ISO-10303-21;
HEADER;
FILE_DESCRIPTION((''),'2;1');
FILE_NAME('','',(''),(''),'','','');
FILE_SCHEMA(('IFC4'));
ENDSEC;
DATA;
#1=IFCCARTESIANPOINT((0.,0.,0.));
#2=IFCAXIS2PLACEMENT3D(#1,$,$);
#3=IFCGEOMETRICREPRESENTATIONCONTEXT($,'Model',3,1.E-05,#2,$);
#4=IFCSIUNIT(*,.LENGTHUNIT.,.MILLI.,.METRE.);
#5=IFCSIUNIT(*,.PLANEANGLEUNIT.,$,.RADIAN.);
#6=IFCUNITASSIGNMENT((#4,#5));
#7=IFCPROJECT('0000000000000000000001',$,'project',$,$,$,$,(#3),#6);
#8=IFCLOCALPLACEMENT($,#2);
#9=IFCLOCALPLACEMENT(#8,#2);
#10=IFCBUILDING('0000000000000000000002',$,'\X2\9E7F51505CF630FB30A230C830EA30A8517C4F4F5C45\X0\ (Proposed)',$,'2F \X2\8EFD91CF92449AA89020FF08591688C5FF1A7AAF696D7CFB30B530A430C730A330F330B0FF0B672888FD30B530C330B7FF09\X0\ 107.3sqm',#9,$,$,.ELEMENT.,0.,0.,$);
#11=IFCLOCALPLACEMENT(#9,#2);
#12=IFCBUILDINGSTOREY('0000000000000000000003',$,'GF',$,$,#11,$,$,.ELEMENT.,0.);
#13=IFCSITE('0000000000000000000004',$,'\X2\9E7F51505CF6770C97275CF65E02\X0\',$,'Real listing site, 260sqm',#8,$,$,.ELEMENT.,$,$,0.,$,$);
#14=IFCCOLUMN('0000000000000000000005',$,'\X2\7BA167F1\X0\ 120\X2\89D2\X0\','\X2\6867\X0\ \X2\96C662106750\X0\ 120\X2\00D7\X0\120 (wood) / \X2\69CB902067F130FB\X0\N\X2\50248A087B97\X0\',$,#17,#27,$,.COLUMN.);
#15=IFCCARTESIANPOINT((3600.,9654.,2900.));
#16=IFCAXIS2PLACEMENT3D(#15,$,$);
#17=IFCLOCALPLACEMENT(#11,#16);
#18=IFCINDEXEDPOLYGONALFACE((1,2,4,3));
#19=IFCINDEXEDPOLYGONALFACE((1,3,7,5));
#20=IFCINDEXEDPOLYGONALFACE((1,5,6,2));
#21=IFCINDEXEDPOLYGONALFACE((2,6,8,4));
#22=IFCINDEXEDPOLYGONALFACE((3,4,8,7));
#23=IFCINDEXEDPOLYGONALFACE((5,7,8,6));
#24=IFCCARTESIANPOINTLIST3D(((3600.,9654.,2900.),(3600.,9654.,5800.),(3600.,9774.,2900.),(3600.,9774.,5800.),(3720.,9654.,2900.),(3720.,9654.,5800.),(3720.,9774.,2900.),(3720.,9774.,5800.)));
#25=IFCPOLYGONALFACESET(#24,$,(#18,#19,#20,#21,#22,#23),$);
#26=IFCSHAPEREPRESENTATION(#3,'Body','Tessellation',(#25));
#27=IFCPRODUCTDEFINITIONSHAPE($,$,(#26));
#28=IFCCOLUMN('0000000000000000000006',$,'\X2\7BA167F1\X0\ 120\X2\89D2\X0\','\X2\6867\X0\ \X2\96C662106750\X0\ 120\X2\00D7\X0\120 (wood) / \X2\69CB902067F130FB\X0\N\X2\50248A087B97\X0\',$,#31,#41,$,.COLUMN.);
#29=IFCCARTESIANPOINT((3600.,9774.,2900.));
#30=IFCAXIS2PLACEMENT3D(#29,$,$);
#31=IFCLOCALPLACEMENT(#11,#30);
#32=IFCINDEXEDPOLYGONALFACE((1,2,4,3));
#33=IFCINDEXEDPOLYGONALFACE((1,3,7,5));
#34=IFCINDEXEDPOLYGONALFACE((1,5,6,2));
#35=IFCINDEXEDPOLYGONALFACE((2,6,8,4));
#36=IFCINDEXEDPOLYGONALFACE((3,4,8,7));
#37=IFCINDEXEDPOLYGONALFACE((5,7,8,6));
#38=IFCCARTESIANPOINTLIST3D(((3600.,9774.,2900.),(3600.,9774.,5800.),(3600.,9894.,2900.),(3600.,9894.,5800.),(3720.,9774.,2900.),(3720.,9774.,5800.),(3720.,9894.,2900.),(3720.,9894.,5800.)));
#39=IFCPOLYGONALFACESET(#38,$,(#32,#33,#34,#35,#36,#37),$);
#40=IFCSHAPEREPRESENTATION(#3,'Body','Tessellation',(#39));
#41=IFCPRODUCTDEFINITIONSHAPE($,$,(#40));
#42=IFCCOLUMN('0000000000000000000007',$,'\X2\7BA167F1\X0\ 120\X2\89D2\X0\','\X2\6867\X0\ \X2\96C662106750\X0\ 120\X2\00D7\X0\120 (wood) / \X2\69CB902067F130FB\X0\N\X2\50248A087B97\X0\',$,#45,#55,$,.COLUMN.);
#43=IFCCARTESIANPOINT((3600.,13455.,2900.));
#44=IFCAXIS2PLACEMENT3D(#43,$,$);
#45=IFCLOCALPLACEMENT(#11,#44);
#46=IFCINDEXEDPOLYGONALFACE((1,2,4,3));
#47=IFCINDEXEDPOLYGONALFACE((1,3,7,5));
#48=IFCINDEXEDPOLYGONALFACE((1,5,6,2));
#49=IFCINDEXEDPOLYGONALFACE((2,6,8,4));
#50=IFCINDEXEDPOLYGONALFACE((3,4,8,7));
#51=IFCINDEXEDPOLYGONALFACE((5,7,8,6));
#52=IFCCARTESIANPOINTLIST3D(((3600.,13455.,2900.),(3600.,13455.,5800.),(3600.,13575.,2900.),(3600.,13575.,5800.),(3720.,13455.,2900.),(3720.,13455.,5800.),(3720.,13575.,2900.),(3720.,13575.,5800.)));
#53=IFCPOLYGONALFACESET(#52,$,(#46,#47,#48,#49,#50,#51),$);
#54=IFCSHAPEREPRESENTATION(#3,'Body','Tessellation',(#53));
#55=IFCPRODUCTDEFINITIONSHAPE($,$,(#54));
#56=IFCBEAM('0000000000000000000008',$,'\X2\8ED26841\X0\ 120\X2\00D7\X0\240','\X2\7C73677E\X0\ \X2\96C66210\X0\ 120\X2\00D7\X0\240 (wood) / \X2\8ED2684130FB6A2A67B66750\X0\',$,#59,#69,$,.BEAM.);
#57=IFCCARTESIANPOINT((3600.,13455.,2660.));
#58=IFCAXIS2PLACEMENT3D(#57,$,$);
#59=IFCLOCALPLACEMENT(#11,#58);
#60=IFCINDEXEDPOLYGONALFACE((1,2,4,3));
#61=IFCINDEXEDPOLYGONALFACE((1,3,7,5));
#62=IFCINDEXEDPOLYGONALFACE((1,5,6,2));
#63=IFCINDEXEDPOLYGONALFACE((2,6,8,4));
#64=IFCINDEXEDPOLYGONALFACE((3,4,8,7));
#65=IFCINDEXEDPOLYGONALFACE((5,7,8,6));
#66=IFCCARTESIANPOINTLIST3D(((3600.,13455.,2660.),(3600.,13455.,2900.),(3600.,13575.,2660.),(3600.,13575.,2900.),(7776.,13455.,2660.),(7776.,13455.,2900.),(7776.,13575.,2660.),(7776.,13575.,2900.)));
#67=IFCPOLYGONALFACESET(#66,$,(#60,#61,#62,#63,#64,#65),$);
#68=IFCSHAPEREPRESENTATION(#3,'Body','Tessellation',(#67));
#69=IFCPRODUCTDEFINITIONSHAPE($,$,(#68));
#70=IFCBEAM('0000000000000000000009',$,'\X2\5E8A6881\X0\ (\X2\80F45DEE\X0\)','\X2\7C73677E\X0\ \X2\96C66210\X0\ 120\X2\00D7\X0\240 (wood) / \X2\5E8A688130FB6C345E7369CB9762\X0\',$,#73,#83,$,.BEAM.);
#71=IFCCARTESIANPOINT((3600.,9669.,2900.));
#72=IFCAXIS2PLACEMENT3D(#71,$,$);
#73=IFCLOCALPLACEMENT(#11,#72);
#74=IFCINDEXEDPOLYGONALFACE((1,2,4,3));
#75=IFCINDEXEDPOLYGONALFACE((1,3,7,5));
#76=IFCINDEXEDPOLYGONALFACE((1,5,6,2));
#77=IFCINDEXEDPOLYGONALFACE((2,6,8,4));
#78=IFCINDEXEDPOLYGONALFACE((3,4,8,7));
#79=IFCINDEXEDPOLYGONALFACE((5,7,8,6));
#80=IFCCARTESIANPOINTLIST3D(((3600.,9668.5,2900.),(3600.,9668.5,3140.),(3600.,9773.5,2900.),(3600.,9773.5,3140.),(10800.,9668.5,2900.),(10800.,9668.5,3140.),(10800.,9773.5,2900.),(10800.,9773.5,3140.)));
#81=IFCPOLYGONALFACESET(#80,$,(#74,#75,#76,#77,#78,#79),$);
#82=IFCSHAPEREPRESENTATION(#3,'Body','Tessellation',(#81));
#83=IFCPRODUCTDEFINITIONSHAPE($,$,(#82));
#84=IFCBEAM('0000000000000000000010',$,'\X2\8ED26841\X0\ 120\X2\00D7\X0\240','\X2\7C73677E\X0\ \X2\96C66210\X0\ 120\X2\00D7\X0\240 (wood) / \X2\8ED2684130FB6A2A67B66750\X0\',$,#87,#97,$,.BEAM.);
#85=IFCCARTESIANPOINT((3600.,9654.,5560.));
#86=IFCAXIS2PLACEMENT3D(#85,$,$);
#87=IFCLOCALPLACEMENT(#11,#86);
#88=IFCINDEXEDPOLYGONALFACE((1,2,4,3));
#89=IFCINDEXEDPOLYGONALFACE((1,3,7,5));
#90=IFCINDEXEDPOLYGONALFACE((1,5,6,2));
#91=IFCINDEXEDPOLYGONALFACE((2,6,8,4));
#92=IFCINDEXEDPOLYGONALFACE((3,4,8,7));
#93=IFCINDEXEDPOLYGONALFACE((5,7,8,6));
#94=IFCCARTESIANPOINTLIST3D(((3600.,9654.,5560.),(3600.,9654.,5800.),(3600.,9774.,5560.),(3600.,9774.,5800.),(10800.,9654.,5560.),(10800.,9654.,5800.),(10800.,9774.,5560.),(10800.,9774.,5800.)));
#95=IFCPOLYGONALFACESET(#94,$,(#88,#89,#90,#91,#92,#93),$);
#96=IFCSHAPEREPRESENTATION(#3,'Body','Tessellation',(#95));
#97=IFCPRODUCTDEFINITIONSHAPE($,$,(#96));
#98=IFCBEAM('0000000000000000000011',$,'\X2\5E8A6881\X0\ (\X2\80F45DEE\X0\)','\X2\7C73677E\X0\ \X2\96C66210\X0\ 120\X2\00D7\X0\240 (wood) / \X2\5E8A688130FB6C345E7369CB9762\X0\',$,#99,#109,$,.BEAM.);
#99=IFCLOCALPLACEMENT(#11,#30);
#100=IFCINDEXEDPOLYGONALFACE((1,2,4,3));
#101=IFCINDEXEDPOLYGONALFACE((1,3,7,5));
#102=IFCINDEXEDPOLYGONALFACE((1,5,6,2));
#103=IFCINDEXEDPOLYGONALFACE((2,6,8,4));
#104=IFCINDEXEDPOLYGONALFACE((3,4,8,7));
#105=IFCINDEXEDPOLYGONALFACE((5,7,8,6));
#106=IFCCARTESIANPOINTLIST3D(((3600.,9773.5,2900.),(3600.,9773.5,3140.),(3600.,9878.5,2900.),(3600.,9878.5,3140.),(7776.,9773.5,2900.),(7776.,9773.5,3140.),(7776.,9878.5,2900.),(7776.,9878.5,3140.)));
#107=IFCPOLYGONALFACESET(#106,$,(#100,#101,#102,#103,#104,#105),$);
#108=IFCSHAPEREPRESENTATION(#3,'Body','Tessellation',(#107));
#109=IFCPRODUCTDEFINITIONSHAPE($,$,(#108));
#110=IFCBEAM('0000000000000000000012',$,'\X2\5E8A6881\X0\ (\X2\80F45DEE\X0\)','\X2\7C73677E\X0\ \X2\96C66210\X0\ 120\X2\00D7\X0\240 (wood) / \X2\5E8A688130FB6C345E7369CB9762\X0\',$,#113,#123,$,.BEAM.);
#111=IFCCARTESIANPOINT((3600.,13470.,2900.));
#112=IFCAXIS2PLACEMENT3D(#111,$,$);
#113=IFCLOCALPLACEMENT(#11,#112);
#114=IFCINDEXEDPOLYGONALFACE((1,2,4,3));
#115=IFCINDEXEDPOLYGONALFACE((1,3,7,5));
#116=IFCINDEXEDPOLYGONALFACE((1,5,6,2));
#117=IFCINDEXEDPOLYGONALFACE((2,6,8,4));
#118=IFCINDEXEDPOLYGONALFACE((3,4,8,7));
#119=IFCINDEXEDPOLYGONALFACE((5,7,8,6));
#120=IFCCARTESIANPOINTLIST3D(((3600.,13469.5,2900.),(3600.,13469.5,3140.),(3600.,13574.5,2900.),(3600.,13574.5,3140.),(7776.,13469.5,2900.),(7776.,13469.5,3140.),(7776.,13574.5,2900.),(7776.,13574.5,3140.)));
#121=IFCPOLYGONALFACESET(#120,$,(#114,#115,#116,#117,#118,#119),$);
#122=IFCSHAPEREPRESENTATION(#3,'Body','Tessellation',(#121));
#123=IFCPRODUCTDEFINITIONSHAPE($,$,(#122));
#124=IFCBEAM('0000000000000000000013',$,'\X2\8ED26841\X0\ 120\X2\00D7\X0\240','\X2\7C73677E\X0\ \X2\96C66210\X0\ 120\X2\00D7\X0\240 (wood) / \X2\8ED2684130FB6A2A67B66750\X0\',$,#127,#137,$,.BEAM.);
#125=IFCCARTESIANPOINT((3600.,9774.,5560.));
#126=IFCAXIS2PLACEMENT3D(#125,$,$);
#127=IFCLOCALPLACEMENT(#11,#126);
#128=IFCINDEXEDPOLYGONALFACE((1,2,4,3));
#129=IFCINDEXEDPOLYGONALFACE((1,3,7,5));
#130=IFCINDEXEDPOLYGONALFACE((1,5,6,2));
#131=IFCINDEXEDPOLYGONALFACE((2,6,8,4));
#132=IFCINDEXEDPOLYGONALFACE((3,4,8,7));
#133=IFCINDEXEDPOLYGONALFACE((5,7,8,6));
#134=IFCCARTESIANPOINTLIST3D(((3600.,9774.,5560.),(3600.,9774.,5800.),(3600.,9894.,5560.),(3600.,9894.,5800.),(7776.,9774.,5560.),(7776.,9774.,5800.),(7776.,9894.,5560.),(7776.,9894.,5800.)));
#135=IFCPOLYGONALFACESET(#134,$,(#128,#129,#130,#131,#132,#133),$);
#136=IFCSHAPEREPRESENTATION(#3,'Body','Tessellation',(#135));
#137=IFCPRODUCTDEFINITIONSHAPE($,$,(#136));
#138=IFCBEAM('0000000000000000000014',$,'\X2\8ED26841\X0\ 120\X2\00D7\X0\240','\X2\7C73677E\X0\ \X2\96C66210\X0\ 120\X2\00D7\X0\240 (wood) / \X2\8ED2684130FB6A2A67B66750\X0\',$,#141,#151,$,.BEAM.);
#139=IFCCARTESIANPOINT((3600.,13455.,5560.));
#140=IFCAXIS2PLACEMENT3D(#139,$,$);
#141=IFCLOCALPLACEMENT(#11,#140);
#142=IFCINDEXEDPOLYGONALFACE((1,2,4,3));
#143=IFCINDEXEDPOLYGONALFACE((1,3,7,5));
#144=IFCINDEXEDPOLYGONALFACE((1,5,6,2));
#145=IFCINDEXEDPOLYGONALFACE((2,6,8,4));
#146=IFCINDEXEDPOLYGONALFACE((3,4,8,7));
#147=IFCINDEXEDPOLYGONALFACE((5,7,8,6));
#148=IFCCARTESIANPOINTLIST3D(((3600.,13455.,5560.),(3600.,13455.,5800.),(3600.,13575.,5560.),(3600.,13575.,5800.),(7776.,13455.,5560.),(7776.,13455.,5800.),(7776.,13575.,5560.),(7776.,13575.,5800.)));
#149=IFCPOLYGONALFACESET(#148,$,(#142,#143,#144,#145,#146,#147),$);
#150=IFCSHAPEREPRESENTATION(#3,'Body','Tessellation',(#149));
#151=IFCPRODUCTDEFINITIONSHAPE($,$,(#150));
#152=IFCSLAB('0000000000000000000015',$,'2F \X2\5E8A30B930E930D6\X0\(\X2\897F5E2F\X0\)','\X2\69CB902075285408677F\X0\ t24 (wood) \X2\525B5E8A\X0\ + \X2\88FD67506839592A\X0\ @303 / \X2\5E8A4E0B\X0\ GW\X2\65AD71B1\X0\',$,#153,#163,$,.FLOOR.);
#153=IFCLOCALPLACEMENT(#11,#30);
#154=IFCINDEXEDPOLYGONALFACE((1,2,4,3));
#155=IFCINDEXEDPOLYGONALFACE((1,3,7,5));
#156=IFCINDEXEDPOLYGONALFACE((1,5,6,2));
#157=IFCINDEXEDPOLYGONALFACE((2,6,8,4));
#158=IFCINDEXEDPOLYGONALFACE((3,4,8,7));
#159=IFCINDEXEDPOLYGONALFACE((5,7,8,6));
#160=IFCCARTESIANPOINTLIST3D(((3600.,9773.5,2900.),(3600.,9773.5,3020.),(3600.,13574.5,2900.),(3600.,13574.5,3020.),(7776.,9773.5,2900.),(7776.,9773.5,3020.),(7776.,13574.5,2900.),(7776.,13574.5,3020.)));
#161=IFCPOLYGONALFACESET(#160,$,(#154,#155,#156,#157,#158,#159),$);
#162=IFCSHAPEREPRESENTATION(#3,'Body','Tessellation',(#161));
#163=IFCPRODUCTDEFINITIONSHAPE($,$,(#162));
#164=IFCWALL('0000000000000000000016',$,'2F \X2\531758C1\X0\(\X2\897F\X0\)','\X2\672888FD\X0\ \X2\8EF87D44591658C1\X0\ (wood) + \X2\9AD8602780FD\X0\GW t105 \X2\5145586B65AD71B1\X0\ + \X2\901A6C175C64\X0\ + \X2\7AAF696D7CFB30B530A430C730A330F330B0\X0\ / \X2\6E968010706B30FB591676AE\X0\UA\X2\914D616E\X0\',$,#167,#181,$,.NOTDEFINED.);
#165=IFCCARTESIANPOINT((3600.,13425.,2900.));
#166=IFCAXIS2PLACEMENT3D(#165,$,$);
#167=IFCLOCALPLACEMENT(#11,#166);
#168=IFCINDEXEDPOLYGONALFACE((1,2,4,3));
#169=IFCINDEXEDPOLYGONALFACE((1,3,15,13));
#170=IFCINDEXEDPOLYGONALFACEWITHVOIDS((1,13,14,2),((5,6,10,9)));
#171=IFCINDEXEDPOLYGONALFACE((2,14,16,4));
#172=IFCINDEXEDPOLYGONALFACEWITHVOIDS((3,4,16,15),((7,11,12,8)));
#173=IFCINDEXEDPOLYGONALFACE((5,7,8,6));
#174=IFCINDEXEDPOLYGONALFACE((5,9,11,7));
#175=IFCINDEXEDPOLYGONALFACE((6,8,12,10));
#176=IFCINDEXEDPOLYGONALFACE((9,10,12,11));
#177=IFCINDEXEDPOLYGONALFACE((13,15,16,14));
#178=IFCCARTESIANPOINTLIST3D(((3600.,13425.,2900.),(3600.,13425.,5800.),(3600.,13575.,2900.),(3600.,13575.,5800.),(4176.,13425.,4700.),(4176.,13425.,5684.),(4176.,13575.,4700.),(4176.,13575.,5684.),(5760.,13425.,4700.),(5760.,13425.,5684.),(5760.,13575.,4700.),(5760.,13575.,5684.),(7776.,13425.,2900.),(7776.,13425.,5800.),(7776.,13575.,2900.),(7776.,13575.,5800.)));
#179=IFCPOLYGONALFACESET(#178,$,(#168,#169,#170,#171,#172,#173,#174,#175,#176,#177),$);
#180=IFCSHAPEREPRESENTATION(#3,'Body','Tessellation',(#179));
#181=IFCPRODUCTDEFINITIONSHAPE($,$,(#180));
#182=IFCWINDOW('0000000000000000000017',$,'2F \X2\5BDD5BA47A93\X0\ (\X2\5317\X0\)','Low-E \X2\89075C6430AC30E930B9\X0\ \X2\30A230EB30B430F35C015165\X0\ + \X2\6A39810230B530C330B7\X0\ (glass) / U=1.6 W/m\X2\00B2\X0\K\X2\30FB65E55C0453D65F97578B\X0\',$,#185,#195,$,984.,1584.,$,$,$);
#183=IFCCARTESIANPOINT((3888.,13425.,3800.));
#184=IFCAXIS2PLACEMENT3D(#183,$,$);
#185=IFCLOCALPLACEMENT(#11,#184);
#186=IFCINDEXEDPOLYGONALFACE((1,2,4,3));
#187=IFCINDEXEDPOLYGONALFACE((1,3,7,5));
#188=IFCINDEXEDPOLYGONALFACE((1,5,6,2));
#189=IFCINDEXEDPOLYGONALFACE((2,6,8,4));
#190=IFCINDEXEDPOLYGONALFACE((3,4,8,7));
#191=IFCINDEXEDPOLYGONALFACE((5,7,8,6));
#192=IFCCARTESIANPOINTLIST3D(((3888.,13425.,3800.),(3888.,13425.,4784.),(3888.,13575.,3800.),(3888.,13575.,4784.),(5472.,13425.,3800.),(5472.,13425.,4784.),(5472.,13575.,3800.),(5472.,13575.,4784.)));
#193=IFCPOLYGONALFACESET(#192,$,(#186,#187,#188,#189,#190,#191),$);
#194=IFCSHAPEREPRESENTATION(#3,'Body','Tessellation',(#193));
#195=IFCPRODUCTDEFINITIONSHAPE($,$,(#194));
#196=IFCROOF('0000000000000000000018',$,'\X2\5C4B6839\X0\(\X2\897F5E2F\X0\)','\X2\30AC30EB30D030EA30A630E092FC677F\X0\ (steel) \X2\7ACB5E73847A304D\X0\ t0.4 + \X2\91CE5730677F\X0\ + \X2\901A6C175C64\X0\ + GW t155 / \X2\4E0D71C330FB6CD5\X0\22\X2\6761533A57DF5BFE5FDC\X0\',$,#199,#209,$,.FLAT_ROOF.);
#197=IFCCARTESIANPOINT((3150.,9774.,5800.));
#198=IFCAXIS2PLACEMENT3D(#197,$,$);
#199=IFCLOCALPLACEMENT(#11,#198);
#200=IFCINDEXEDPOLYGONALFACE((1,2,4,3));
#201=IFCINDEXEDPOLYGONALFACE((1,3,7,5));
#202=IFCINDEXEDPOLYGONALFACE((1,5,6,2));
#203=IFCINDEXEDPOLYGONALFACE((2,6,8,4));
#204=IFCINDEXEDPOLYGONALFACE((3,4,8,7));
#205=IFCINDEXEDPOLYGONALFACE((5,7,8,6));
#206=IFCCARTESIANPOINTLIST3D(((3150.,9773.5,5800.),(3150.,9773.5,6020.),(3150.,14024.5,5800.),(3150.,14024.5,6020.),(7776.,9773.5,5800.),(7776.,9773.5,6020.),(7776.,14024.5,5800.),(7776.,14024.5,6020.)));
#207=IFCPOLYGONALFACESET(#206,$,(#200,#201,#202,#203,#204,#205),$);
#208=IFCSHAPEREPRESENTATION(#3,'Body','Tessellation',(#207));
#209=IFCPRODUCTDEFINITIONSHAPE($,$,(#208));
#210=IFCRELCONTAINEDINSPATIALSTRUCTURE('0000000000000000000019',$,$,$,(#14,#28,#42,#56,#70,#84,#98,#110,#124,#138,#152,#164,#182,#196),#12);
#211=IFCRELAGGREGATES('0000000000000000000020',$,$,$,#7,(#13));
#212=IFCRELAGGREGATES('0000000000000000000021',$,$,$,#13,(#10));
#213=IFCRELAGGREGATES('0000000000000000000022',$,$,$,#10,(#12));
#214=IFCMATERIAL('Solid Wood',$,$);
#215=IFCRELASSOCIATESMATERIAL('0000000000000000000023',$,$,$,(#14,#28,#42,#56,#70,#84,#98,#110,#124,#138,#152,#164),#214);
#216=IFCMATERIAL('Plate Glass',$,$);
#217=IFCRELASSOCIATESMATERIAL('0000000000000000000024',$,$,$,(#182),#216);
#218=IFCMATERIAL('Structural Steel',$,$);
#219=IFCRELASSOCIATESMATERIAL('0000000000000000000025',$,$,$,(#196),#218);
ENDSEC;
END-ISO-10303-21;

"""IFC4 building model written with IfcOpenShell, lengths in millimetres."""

from ifc_helpers import new_model, si_unit, frame, frame_2d, origin, place, context, project, spatial, rectangle, extrude, material, element, fill, save


model = new_model("IFC4")

# Units and contexts
model_context = context("Model", 3, precision=1e-05, world=origin())
ifc_project = project(units=[si_unit("LENGTHUNIT", "METRE", prefix="MILLI"), si_unit("PLANEANGLEUNIT", "RADIAN")], contexts=[model_context])

# Site, building, storey
site_placement = place(None, origin())
site = spatial("IfcSite", under=ifc_project, at=site_placement, Name="鹿児島県霧島市", ObjectType="Real listing site, 260sqm", CompositionType="ELEMENT", RefElevation=0.0)
building_placement = place(site_placement, origin())
building = spatial("IfcBuilding", under=site, at=building_placement, Name="鹿児島・アトリエ兼住居 (Proposed)", ObjectType="2F 軽量鉄骨造（外装：窯業系サイディング＋木製サッシ） 107.3sqm", CompositionType="ELEMENT", ElevationOfRefHeight=0.0, ElevationOfTerrain=0.0)
storey_placement = place(building_placement, origin())
storey = spatial("IfcBuildingStorey", under=building, at=storey_placement, Name="GF", CompositionType="ELEMENT", Elevation=0.0)

# Columns
ifc_material_1 = material(Name="Solid Wood")
column_1_placement = place(storey_placement, frame((3600.0, 9654.0, 2900.0)))
element("IfcColumn", 1, at=column_1_placement, inside=storey, material=ifc_material_1, Name="管柱 120角", Description="桧 集成材 120×120 (wood) / 構造柱・N値計算", PredefinedType="COLUMN", context=model_context, shape_type="SweptSolid", body=[
    extrude(rectangle(XDim=120.0, YDim=120.0, at=frame_2d((60.0, 60.0))), frame((3600.0, 9654.0, 2900.0)), (0.0, 0.0, 1.0), 2900.0),
])
column_2_placement = place(storey_placement, frame((3600.0, 9774.0, 2900.0)))
element("IfcColumn", 2, at=column_2_placement, inside=storey, material=ifc_material_1, Name="管柱 120角", Description="桧 集成材 120×120 (wood) / 構造柱・N値計算", PredefinedType="COLUMN", context=model_context, shape_type="SweptSolid", body=[
    extrude(rectangle(XDim=120.0, YDim=120.0, at=frame_2d((60.0, 60.0))), frame((3600.0, 9774.0, 2900.0)), (0.0, 0.0, 1.0), 2900.0),
])
column_3_placement = place(storey_placement, frame((3600.0, 13455.0, 2900.0)))
element("IfcColumn", 3, at=column_3_placement, inside=storey, material=ifc_material_1, Name="管柱 120角", Description="桧 集成材 120×120 (wood) / 構造柱・N値計算", PredefinedType="COLUMN", context=model_context, shape_type="SweptSolid", body=[
    extrude(rectangle(XDim=120.0, YDim=120.0, at=frame_2d((60.0, 60.0))), frame((3600.0, 13455.0, 2900.0)), (0.0, 0.0, 1.0), 2900.0),
])

# Beams
beam_1_placement = place(storey_placement, frame((3600.0, 13455.0, 2660.0)))
element("IfcBeam", 4, at=beam_1_placement, inside=storey, material=ifc_material_1, Name="軒桁 120×240", Description="米松 集成 120×240 (wood) / 軒桁・横架材", PredefinedType="BEAM", context=model_context, shape_type="SweptSolid", body=[
    extrude(rectangle(XDim=4176.0, YDim=120.0, at=frame_2d((2088.0, 60.0))), frame((3600.0, 13455.0, 2660.0)), (0.0, 0.0, 1.0), 240.0),
])
beam_2_placement = place(storey_placement, frame((3600.0, 9669.0, 2900.0)))
element("IfcBeam", 5, at=beam_2_placement, inside=storey, material=ifc_material_1, Name="床梁 (胴差)", Description="米松 集成 120×240 (wood) / 床梁・水平構面", PredefinedType="BEAM", context=model_context, shape_type="SweptSolid", body=[
    extrude(rectangle(XDim=7200.0, YDim=105.0, at=frame_2d((3600.0, 52.0))), frame((3600.0, 9669.0, 2900.0)), (0.0, 0.0, 1.0), 240.0),
])
beam_3_placement = place(storey_placement, frame((3600.0, 9654.0, 5560.0)))
element("IfcBeam", 6, at=beam_3_placement, inside=storey, material=ifc_material_1, Name="軒桁 120×240", Description="米松 集成 120×240 (wood) / 軒桁・横架材", PredefinedType="BEAM", context=model_context, shape_type="SweptSolid", body=[
    extrude(rectangle(XDim=7200.0, YDim=120.0, at=frame_2d((3600.0, 60.0))), frame((3600.0, 9654.0, 5560.0)), (0.0, 0.0, 1.0), 240.0),
])
beam_4_placement = place(storey_placement, frame((3600.0, 9774.0, 2900.0)))
element("IfcBeam", 7, at=beam_4_placement, inside=storey, material=ifc_material_1, Name="床梁 (胴差)", Description="米松 集成 120×240 (wood) / 床梁・水平構面", PredefinedType="BEAM", context=model_context, shape_type="SweptSolid", body=[
    extrude(rectangle(XDim=4176.0, YDim=105.0, at=frame_2d((2088.0, 52.0))), frame((3600.0, 9774.0, 2900.0)), (0.0, 0.0, 1.0), 240.0),
])
beam_5_placement = place(storey_placement, frame((3600.0, 13470.0, 2900.0)))
element("IfcBeam", 8, at=beam_5_placement, inside=storey, material=ifc_material_1, Name="床梁 (胴差)", Description="米松 集成 120×240 (wood) / 床梁・水平構面", PredefinedType="BEAM", context=model_context, shape_type="SweptSolid", body=[
    extrude(rectangle(XDim=4176.0, YDim=105.0, at=frame_2d((2088.0, 52.0))), frame((3600.0, 13470.0, 2900.0)), (0.0, 0.0, 1.0), 240.0),
])
beam_6_placement = place(storey_placement, frame((3600.0, 9774.0, 5560.0)))
element("IfcBeam", 9, at=beam_6_placement, inside=storey, material=ifc_material_1, Name="軒桁 120×240", Description="米松 集成 120×240 (wood) / 軒桁・横架材", PredefinedType="BEAM", context=model_context, shape_type="SweptSolid", body=[
    extrude(rectangle(XDim=4176.0, YDim=120.0, at=frame_2d((2088.0, 60.0))), frame((3600.0, 9774.0, 5560.0)), (0.0, 0.0, 1.0), 240.0),
])
beam_7_placement = place(storey_placement, frame((3600.0, 13455.0, 5560.0)))
element("IfcBeam", 10, at=beam_7_placement, inside=storey, material=ifc_material_1, Name="軒桁 120×240", Description="米松 集成 120×240 (wood) / 軒桁・横架材", PredefinedType="BEAM", context=model_context, shape_type="SweptSolid", body=[
    extrude(rectangle(XDim=4176.0, YDim=120.0, at=frame_2d((2088.0, 60.0))), frame((3600.0, 13455.0, 5560.0)), (0.0, 0.0, 1.0), 240.0),
])

# Slab
slab_placement = place(storey_placement, frame((3600.0, 9774.0, 2900.0)))
element("IfcSlab", 11, at=slab_placement, inside=storey, material=ifc_material_1, Name="2F 床スラブ(西帯)", Description="構造用合板 t24 (wood) 剛床 + 製材根太 @303 / 床下 GW断熱", PredefinedType="FLOOR", context=model_context, shape_type="SweptSolid", body=[
    extrude(rectangle(XDim=4176.0, YDim=3801.0, at=frame_2d((2088.0, 1900.0))), frame((3600.0, 9774.0, 2900.0)), (0.0, 0.0, 1.0), 120.0),
])

# Wall, opening, window
wall_1_placement = place(storey_placement, frame((3600.0, 13425.0, 2900.0)))
wall_1 = element("IfcWall", 12, at=wall_1_placement, inside=storey, material=ifc_material_1, Name="2F 北壁(西)", Description="木製 軸組外壁 (wood) + 高性能GW t105 充填断熱 + 通気層 + 窯業系サイディング / 準耐火・外皮UA配慮", PredefinedType="NOTDEFINED", context=model_context, shape_type="SweptSolid", body=[
    extrude(rectangle(XDim=4176.0, YDim=150.0, at=frame_2d((2088.0, 75.0))), frame((3600.0, 13425.0, 2900.0)), (0.0, 0.0, 1.0), 2900.0),
])
opening_placement = place(storey_placement, frame((3888.0, 13425.0, 3800.0)))
opening = element("IfcOpeningElement", 13, at=opening_placement, cuts=wall_1, PredefinedType="NOTDEFINED", context=model_context, shape_type="SweptSolid", body=[
    extrude(rectangle(XDim=1584.0, YDim=150.0, at=frame_2d((792.0, 75.0))), frame((3888.0, 13425.0, 3800.0)), (0.0, 0.0, 1.0), 984.0),
])
ifc_material_2 = material(Name="Plate Glass")
window_placement = place(storey_placement, frame((3888.0, 13425.0, 3800.0)))
window = element("IfcWindow", 14, at=window_placement, inside=storey, material=ifc_material_2, Name="2F 寝室窓 (北)", Description="Low-E 複層ガラス アルゴン封入 + 樹脂サッシ (glass) / U=1.6 W/m²K・日射取得型", OverallHeight=984.0, OverallWidth=1584.0, context=model_context, shape_type="SweptSolid", body=[
    extrude(rectangle(XDim=1584.0, YDim=150.0, at=frame_2d((792.0, 75.0))), frame((3888.0, 13425.0, 3800.0)), (0.0, 0.0, 1.0), 984.0),
])
fill(opening, window)

# Roof
ifc_material_3 = material(Name="Structural Steel")
for number, where, name in (
    (15, (3150.0, 9774.0, 5800.0), "屋根(西帯)"),
):
    element("IfcRoof", number, at=place(storey_placement, frame(where)), inside=storey, material=ifc_material_3, Name=name, Description="ガルバリウム鋼板 (steel) 立平葺き t0.4 + 野地板 + 通気層 + GW t155 / 不燃・法22条区域対応", PredefinedType="FLAT_ROOF", context=model_context, shape_type="SweptSolid", body=[
        extrude(rectangle(XDim=4626.0, YDim=4251.0, at=frame_2d((2313.0, 2125.0))), frame((3150.0, 9774.0, 5800.0)), (0.0, 0.0, 1.0), 220.0),
    ])

save(model, "model.ifc")
